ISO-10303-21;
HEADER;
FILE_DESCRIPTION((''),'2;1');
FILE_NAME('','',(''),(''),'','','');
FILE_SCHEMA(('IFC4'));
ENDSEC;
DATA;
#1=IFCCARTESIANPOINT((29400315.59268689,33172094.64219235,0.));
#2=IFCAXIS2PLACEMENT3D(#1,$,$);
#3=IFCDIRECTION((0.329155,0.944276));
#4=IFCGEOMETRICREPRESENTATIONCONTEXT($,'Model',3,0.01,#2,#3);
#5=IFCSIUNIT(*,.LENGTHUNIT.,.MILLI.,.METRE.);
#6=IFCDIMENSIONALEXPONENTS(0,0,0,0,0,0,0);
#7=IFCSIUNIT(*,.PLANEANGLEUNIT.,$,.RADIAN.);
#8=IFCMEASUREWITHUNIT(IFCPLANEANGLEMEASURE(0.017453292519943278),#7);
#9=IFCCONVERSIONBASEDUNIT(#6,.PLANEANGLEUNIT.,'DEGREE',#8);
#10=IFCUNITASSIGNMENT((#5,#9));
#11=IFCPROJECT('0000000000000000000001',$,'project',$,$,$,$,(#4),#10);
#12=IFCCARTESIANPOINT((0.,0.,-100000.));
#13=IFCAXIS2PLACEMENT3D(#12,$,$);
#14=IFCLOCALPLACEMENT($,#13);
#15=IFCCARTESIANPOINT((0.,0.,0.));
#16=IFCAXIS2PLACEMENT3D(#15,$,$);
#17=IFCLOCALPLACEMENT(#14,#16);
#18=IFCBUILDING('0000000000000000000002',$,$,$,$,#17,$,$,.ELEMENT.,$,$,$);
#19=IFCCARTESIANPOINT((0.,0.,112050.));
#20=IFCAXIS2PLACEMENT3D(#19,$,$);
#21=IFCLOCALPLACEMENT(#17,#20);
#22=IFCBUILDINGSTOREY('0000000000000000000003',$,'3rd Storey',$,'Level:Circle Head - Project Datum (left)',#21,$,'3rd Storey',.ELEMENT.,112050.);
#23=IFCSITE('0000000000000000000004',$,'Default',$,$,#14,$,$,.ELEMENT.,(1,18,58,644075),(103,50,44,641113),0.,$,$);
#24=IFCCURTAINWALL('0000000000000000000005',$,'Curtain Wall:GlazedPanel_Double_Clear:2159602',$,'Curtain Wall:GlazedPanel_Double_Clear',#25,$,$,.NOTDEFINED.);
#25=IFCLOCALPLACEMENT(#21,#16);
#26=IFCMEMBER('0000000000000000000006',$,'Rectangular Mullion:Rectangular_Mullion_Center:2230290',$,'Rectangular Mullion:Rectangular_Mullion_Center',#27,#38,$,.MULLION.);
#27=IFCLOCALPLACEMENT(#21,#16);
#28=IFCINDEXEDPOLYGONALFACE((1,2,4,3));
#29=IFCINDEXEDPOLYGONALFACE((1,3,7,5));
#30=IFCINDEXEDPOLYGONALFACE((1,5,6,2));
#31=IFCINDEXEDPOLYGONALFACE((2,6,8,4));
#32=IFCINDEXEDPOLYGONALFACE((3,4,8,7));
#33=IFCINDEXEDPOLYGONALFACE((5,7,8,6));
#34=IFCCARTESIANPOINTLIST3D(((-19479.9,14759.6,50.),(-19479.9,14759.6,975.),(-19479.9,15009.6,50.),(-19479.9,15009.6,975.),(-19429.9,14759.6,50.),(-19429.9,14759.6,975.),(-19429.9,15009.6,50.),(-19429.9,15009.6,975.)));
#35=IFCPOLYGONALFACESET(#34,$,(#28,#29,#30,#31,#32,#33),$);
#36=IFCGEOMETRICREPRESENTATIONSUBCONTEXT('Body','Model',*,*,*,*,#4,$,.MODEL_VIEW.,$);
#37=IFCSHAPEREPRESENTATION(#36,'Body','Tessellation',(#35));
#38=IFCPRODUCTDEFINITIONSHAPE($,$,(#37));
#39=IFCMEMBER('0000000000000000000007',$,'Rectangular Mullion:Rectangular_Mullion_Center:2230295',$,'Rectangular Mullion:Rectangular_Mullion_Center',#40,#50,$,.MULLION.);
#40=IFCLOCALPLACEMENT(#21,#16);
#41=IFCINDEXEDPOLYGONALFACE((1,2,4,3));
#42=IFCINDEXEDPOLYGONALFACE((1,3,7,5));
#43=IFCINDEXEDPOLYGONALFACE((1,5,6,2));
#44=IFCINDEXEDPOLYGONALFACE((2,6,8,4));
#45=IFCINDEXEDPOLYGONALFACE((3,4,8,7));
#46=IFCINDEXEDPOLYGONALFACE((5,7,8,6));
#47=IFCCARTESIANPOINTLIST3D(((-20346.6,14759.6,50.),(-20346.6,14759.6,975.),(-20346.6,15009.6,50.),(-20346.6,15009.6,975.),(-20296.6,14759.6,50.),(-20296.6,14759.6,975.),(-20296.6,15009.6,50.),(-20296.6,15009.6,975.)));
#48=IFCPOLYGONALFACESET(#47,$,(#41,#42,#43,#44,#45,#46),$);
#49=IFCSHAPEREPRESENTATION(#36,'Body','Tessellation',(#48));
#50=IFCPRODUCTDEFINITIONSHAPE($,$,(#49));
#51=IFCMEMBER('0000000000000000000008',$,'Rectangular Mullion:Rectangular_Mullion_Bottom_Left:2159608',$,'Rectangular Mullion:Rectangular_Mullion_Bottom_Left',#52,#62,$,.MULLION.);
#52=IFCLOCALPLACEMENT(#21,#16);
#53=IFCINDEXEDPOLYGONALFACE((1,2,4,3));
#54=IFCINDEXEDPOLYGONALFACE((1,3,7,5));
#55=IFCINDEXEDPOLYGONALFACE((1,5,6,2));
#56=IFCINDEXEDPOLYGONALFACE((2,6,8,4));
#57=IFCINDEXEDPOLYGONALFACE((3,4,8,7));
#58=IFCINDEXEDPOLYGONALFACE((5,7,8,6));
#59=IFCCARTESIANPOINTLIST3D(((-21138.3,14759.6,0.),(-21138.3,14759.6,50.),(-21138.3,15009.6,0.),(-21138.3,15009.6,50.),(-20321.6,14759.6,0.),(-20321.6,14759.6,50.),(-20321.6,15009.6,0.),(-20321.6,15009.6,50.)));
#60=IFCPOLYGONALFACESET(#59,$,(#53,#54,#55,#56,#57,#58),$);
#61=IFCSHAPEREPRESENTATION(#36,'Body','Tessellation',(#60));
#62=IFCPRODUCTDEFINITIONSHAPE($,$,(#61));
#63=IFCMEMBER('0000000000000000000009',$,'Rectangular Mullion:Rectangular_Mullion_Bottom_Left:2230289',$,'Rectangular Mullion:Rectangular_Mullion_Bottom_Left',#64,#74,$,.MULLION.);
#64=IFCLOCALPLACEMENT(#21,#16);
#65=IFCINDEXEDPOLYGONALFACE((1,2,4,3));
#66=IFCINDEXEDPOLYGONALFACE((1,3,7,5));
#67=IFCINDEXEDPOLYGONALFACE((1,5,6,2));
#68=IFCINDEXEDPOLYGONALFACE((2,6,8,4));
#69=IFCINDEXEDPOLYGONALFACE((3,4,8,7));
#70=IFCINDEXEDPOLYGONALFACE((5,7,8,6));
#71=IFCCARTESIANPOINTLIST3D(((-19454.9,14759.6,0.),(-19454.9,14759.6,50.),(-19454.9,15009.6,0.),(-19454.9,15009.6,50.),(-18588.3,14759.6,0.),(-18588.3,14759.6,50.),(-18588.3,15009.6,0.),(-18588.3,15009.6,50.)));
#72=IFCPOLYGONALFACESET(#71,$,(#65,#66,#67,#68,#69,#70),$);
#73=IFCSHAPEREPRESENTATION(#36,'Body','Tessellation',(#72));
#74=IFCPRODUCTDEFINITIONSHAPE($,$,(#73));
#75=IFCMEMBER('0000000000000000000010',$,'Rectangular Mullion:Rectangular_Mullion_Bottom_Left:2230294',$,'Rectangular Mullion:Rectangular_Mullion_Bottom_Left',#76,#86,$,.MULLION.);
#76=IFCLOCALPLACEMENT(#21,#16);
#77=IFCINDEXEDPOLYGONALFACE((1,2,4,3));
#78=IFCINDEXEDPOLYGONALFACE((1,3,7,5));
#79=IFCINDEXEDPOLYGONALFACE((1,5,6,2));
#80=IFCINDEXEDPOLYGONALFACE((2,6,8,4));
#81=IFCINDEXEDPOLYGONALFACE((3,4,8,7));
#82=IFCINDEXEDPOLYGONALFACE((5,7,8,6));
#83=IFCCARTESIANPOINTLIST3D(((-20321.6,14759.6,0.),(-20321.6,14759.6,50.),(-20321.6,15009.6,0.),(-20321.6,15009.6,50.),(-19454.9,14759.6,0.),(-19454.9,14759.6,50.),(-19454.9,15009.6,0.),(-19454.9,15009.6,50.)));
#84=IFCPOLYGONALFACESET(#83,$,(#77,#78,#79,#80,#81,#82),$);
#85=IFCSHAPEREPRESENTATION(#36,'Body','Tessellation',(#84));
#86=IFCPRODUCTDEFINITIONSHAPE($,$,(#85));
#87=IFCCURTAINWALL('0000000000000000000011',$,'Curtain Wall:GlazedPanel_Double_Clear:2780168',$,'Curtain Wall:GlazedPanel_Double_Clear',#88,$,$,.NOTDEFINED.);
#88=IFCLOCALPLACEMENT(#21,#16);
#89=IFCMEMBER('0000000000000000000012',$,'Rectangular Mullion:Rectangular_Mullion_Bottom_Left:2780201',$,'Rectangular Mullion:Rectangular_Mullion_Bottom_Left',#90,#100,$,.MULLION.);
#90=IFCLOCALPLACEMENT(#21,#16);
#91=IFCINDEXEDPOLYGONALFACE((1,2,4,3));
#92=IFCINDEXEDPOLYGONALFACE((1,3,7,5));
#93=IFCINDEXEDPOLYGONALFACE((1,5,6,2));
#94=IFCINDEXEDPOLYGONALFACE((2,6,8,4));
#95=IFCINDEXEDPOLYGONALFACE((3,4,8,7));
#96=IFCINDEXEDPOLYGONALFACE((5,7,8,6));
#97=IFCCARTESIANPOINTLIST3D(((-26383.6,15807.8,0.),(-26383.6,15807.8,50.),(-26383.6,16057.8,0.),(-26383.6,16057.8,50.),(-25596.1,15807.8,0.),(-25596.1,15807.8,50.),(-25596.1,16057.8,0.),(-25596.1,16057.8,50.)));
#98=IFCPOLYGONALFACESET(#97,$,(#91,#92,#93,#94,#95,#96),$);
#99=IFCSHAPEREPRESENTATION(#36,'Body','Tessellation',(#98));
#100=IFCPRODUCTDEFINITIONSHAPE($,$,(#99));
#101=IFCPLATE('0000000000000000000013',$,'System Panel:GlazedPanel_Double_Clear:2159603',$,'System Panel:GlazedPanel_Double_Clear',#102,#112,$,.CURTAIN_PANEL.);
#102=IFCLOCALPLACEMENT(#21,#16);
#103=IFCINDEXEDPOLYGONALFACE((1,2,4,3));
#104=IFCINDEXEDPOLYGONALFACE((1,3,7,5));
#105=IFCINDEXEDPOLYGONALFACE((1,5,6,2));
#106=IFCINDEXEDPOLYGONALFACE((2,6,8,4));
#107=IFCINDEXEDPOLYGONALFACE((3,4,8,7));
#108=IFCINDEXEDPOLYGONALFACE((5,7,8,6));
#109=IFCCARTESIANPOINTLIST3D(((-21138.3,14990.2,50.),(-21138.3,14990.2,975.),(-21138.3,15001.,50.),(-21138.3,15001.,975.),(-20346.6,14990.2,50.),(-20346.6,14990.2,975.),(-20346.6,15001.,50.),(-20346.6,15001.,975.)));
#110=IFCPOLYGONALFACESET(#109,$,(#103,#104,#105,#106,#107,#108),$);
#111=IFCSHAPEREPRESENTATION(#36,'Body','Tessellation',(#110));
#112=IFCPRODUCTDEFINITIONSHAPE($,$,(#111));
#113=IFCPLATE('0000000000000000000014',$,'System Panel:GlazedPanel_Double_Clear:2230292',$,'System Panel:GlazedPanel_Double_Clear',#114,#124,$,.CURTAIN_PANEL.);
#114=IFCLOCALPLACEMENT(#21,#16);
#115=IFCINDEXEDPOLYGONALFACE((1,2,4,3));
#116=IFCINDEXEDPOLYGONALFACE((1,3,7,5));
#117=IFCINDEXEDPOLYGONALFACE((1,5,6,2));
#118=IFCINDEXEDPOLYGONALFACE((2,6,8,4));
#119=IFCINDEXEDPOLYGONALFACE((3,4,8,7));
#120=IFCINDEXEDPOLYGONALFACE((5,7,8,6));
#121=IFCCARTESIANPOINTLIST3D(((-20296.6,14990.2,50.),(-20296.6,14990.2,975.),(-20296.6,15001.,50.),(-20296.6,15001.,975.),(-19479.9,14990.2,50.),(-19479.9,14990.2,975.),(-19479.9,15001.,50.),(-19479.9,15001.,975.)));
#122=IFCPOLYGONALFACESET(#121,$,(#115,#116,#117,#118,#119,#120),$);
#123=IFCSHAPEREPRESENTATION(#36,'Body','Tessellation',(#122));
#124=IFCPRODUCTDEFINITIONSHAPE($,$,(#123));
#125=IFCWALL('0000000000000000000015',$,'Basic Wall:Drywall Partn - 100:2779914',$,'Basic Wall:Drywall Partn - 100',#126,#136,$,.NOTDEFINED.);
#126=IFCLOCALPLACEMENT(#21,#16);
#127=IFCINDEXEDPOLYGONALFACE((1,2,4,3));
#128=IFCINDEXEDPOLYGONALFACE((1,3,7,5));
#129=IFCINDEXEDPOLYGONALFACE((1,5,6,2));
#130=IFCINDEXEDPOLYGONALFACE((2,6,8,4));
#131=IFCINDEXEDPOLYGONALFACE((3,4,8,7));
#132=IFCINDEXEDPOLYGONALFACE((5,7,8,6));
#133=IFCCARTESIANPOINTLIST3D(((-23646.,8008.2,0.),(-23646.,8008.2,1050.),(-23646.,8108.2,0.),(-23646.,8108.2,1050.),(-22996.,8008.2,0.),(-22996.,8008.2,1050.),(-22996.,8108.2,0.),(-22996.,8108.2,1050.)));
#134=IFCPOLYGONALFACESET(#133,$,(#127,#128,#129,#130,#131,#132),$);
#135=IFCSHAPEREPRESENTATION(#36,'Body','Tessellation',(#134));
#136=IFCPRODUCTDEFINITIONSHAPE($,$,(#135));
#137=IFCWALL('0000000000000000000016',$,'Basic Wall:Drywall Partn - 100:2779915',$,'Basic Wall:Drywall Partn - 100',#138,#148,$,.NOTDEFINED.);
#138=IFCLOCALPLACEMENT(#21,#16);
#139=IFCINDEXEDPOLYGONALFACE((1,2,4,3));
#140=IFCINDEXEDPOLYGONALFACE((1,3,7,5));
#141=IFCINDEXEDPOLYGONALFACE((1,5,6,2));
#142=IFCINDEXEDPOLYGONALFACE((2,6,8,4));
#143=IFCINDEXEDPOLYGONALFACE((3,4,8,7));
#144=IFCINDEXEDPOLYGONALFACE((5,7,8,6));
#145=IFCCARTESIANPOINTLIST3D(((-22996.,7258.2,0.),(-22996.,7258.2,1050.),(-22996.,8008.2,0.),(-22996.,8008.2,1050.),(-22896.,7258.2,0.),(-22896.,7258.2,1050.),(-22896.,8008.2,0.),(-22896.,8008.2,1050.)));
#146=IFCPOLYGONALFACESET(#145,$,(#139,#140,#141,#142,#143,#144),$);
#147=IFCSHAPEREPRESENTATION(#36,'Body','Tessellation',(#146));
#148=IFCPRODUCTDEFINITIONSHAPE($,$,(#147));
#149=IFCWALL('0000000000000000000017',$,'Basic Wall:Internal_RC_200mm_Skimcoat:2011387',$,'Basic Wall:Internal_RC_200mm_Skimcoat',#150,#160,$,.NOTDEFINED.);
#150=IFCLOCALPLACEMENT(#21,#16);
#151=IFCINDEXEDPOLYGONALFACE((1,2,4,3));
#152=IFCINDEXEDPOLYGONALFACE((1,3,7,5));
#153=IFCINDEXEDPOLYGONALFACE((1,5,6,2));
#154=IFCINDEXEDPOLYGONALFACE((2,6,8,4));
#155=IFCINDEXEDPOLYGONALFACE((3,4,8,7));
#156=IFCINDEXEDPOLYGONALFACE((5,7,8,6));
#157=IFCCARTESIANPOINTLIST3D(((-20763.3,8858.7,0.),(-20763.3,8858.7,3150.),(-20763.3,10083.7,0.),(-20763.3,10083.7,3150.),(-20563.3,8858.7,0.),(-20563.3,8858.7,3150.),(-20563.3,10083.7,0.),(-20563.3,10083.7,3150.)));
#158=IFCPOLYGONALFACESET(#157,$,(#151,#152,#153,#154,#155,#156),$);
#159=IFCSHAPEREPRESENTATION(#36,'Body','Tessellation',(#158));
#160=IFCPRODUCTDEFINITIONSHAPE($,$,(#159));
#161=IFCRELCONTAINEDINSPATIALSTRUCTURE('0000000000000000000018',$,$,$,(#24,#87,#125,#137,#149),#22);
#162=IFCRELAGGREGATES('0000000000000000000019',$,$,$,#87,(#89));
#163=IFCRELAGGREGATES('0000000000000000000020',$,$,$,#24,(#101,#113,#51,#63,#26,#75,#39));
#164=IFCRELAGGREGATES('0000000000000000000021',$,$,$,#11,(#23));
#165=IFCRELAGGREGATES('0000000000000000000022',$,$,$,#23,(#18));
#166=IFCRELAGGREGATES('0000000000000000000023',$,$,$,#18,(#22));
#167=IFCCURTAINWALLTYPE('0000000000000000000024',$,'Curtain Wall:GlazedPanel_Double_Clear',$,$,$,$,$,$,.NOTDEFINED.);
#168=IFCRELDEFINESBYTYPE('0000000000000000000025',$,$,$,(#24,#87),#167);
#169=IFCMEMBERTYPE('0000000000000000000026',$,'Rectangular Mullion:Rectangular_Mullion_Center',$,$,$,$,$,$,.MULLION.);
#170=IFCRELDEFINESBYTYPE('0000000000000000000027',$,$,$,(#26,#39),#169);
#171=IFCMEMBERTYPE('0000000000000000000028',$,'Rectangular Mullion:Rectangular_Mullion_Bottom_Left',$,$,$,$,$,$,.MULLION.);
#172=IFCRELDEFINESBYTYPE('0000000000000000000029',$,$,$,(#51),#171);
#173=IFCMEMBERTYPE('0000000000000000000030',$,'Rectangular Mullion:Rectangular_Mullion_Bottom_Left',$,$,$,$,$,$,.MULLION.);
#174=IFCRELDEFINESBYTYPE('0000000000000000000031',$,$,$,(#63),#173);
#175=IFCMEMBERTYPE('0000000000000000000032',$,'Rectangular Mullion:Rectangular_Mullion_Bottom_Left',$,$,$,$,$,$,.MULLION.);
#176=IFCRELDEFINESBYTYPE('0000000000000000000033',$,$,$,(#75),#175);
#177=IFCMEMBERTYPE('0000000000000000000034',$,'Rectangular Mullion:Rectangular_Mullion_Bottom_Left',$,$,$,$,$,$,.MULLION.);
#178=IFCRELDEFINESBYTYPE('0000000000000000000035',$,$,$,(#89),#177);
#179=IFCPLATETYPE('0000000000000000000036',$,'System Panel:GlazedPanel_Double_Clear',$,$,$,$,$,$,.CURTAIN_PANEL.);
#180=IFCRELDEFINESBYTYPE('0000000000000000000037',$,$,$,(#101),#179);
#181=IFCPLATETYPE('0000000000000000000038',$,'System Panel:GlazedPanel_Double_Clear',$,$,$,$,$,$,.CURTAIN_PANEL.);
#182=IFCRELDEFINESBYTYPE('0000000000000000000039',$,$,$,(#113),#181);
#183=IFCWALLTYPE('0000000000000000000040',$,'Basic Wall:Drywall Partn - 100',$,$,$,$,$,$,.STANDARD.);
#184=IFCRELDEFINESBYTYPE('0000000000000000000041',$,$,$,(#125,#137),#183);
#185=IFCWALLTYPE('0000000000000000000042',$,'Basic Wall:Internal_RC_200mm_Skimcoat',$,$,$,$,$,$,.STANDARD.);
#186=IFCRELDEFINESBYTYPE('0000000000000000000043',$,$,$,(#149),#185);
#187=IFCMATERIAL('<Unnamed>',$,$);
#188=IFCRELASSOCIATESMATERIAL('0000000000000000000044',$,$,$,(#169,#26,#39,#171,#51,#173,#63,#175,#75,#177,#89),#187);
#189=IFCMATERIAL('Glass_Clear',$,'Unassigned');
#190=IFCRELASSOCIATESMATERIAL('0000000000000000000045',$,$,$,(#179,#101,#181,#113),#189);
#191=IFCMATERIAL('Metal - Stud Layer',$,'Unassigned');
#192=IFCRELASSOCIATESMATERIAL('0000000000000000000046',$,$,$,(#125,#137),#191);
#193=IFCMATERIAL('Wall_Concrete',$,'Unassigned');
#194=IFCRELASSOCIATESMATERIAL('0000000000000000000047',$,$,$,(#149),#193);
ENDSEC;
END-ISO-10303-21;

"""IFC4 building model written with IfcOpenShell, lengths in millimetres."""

from ifc_helpers import new_model, entity, si_unit, converted_unit, direction, frame, origin, place, context, subcontext, project, spatial, indexed_curve, outline, extrude, source, transform, mapped, material, type_object, type_shapes, element, aggregate, save


model = new_model("IFC4")

# Units and contexts
model_context = context("Model", 3, precision=0.01, world=frame((29400315.59268689, 33172094.64219235, 0.0)), true_north=direction((0.329155, 0.944276)))
body_context = subcontext(model_context, "Body", "Model", "MODEL_VIEW")
ifc_project = project(units=[si_unit("LENGTHUNIT", "METRE", prefix="MILLI"), converted_unit("PLANEANGLEUNIT", "DEGREE", entity("IfcPlaneAngleMeasure", 0.017453292519943278), si_unit("PLANEANGLEUNIT", "RADIAN"), dimensions=[0, 0, 0, 0, 0, 0, 0])], contexts=[model_context])

# Site, building, storey
site_placement = place(None, frame((0.0, 0.0, -100000.0)))
site = spatial("IfcSite", under=ifc_project, at=site_placement, Name="Default", CompositionType="ELEMENT", RefLatitude=(1, 18, 58, 644075), RefLongitude=(103, 50, 44, 641113), RefElevation=0.0)
building_placement = place(site_placement, origin())
building = spatial("IfcBuilding", under=site, at=building_placement, CompositionType="ELEMENT")
storey_placement = place(building_placement, frame((0.0, 0.0, 112050.0)))
storey = spatial("IfcBuildingStorey", under=building, at=storey_placement, Name="3rd Storey", ObjectType="Level:Circle Head - Project Datum (left)", LongName="3rd Storey", CompositionType="ELEMENT", Elevation=112050.0)

# Curtain wall, members
curtain_wall_type = type_object("IfcCurtainWallType", Name="Curtain Wall:GlazedPanel_Double_Clear", PredefinedType="NOTDEFINED")
curtain_wall_1_placement = place(storey_placement, frame((0.0, 0.0, -112050.0)))
curtain_wall_1 = element("IfcCurtainWall", 1, at=curtain_wall_1_placement, inside=storey, type_object=curtain_wall_type, Name="Curtain Wall:GlazedPanel_Double_Clear:2159602", ObjectType="Curtain Wall:GlazedPanel_Double_Clear", PredefinedType="NOTDEFINED")
ifc_material_1 = material(Name="<Unnamed>")
member_type_1 = type_object("IfcMemberType", Name="Rectangular Mullion:Rectangular_Mullion_Center", PredefinedType="MULLION", material=ifc_material_1)
shared_shape_1 = source(origin(), body_context, "Body", "SweptSolid", [
    extrude(outline(indexed_curve([(-25.0, -125.0), (25.0, -125.0), (25.0, 125.0), (-25.0, 125.0), (-25.0, -125.0)], self_intersect=False)), frame((0.0, 0.0, -925.0), z_axis=(0.0, 0.0, 1.0), x_axis=(-1.0, 0.0, 0.0)), (0.0, 0.0, 1.0), 925.0),
])
type_shapes(member_type_1, [shared_shape_1])
member_1_placement = place(curtain_wall_1_placement, frame((-19454.9, 14884.6, 112100.0), z_axis=(0.0, 0.0, -1.0), x_axis=(1.0, 0.0, 0.0)))
member_1 = element("IfcMember", 2, at=member_1_placement, type_object=member_type_1, material=ifc_material_1, Name="Rectangular Mullion:Rectangular_Mullion_Center:2230290", ObjectType="Rectangular Mullion:Rectangular_Mullion_Center", PredefinedType="MULLION", context=body_context, shape_type="MappedRepresentation", body=[
    mapped(shared_shape_1, transform((0.0, 0.0, 0.0), scale=1.0)),
])
member_2_placement = place(curtain_wall_1_placement, frame((-20321.6, 14884.6, 112100.0), z_axis=(0.0, 0.0, -1.0), x_axis=(1.0, 0.0, 0.0)))
member_2 = element("IfcMember", 3, at=member_2_placement, type_object=member_type_1, material=ifc_material_1, Name="Rectangular Mullion:Rectangular_Mullion_Center:2230295", ObjectType="Rectangular Mullion:Rectangular_Mullion_Center", PredefinedType="MULLION", context=body_context, shape_type="MappedRepresentation", body=[
    mapped(shared_shape_1, transform((0.0, 0.0, 0.0), scale=1.0)),
])
member_type_2 = type_object("IfcMemberType", Name="Rectangular Mullion:Rectangular_Mullion_Bottom_Left", PredefinedType="MULLION", material=ifc_material_1)
shared_shape_2 = source(origin(), body_context, "Body", "SweptSolid", [
    extrude(outline(indexed_curve([(-25.0, -125.0), (25.0, -125.0), (25.0, 125.0), (-25.0, 125.0), (-25.0, -125.0)], self_intersect=False)), frame((-25.0, 0.0, -816.7), z_axis=(0.0, 0.0, 1.0), x_axis=(-1.0, 0.0, 0.0)), (0.0, 0.0, 1.0), 816.7),
])
type_shapes(member_type_2, [shared_shape_2])
member_3_placement = place(curtain_wall_1_placement, frame((-21138.3, 14884.6, 112050.0), z_axis=(-1.0, 0.0, 0.0), x_axis=(0.0, 0.0, -1.0)))
member_3 = element("IfcMember", 4, at=member_3_placement, type_object=member_type_2, material=ifc_material_1, Name="Rectangular Mullion:Rectangular_Mullion_Bottom_Left:2159608", ObjectType="Rectangular Mullion:Rectangular_Mullion_Bottom_Left", PredefinedType="MULLION", context=body_context, shape_type="MappedRepresentation", body=[
    mapped(shared_shape_2, transform((0.0, 0.0, 0.0), scale=1.0)),
])
member_type_3 = type_object("IfcMemberType", Name="Rectangular Mullion:Rectangular_Mullion_Bottom_Left", PredefinedType="MULLION", material=ifc_material_1)
shared_shape_3 = source(origin(), body_context, "Body", "SweptSolid", [
    extrude(outline(indexed_curve([(-25.0, -125.0), (25.0, -125.0), (25.0, 125.0), (-25.0, 125.0), (-25.0, -125.0)], self_intersect=False)), frame((-25.0, 0.0, -866.7), z_axis=(0.0, 0.0, 1.0), x_axis=(-1.0, 0.0, 0.0)), (0.0, 0.0, 1.0), 866.7),
])
type_shapes(member_type_3, [shared_shape_3])
member_4_placement = place(curtain_wall_1_placement, frame((-19454.9, 14884.6, 112050.0), z_axis=(-1.0, 0.0, 0.0), x_axis=(0.0, 0.0, -1.0)))
member_4 = element("IfcMember", 5, at=member_4_placement, type_object=member_type_3, material=ifc_material_1, Name="Rectangular Mullion:Rectangular_Mullion_Bottom_Left:2230289", ObjectType="Rectangular Mullion:Rectangular_Mullion_Bottom_Left", PredefinedType="MULLION", context=body_context, shape_type="MappedRepresentation", body=[
    mapped(shared_shape_3, transform((0.0, 0.0, 0.0), scale=1.0)),
])
member_type_4 = type_object("IfcMemberType", Name="Rectangular Mullion:Rectangular_Mullion_Bottom_Left", PredefinedType="MULLION", material=ifc_material_1)
shared_shape_4 = source(origin(), body_context, "Body", "SweptSolid", [
    extrude(outline(indexed_curve([(-25.0, -125.0), (25.0, -125.0), (25.0, 125.0), (-25.0, 125.0), (-25.0, -125.0)], self_intersect=False)), frame((-25.0, 0.0, -866.7), z_axis=(0.0, 0.0, 1.0), x_axis=(-1.0, 0.0, 0.0)), (0.0, 0.0, 1.0), 866.7),
])
type_shapes(member_type_4, [shared_shape_4])
member_5_placement = place(curtain_wall_1_placement, frame((-20321.6, 14884.6, 112050.0), z_axis=(-1.0, 0.0, 0.0), x_axis=(0.0, 0.0, -1.0)))
member_5 = element("IfcMember", 6, at=member_5_placement, type_object=member_type_4, material=ifc_material_1, Name="Rectangular Mullion:Rectangular_Mullion_Bottom_Left:2230294", ObjectType="Rectangular Mullion:Rectangular_Mullion_Bottom_Left", PredefinedType="MULLION", context=body_context, shape_type="MappedRepresentation", body=[
    mapped(shared_shape_4, transform((0.0, 0.0, 0.0), scale=1.0)),
])

# Curtain wall, member
curtain_wall_2_placement = place(storey_placement, frame((0.0, 0.0, -112050.0)))
curtain_wall_2 = element("IfcCurtainWall", 7, at=curtain_wall_2_placement, inside=storey, type_object=curtain_wall_type, Name="Curtain Wall:GlazedPanel_Double_Clear:2780168", ObjectType="Curtain Wall:GlazedPanel_Double_Clear", PredefinedType="NOTDEFINED")
member_type_5 = type_object("IfcMemberType", Name="Rectangular Mullion:Rectangular_Mullion_Bottom_Left", PredefinedType="MULLION", material=ifc_material_1)
shared_shape_5 = source(origin(), body_context, "Body", "SweptSolid", [
    extrude(outline(indexed_curve([(-25.0, -125.0), (25.0, -125.0), (25.0, 125.0), (-25.0, 125.0), (-25.0, -125.0)], self_intersect=False)), frame((-25.0, 0.0, -787.5), z_axis=(0.0, 0.0, 1.0), x_axis=(-1.0, 0.0, 0.0)), (0.0, 0.0, 1.0), 787.5),
])
type_shapes(member_type_5, [shared_shape_5])
member_6_placement = place(curtain_wall_2_placement, frame((-26383.6, 15932.8, 112050.0), z_axis=(-1.0, 0.0, 0.0), x_axis=(0.0, 0.0, -1.0)))
member_6 = element("IfcMember", 8, at=member_6_placement, type_object=member_type_5, material=ifc_material_1, Name="Rectangular Mullion:Rectangular_Mullion_Bottom_Left:2780201", ObjectType="Rectangular Mullion:Rectangular_Mullion_Bottom_Left", PredefinedType="MULLION", context=body_context, shape_type="MappedRepresentation", body=[
    mapped(shared_shape_5, transform((0.0, 0.0, 0.0), scale=1.0)),
])
aggregate(curtain_wall_2, [member_6])

# Plates
ifc_material_2 = material(Name="Glass_Clear", Category="Unassigned")
plate_type_1 = type_object("IfcPlateType", Name="System Panel:GlazedPanel_Double_Clear", PredefinedType="CURTAIN_PANEL", material=ifc_material_2)
shared_shape_6 = source(origin(), body_context, "Body", "SweptSolid", [
    extrude(outline(indexed_curve([(-5.4, -395.8), (5.4, -395.8), (5.4, 395.8), (-5.4, 395.8), (-5.4, -395.8)], self_intersect=False)), frame((0.0, 111.0, 0.0), z_axis=(0.0, 0.0, 1.0), x_axis=(0.0, 1.0, 0.0)), (0.0, 0.0, 1.0), 925.0),
])
type_shapes(plate_type_1, [shared_shape_6])
plate_1_placement = place(curtain_wall_1_placement, frame((-20742.5, 14884.6, 112100.0)))
plate_1 = element("IfcPlate", 9, at=plate_1_placement, type_object=plate_type_1, material=ifc_material_2, Name="System Panel:GlazedPanel_Double_Clear:2159603", ObjectType="System Panel:GlazedPanel_Double_Clear", PredefinedType="CURTAIN_PANEL", context=body_context, shape_type="MappedRepresentation", body=[
    mapped(shared_shape_6, transform((0.0, 0.0, 0.0), scale=1.0)),
])
plate_type_2 = type_object("IfcPlateType", Name="System Panel:GlazedPanel_Double_Clear", PredefinedType="CURTAIN_PANEL", material=ifc_material_2)
shared_shape_7 = source(origin(), body_context, "Body", "SweptSolid", [
    extrude(outline(indexed_curve([(-5.4, -408.3), (5.4, -408.3), (5.4, 408.3), (-5.4, 408.3), (-5.4, -408.3)], self_intersect=False)), frame((0.0, 111.0, 0.0), z_axis=(0.0, 0.0, 1.0), x_axis=(0.0, 1.0, 0.0)), (0.0, 0.0, 1.0), 925.0),
])
type_shapes(plate_type_2, [shared_shape_7])
plate_2_placement = place(curtain_wall_1_placement, frame((-19888.3, 14884.6, 112100.0)))
plate_2 = element("IfcPlate", 10, at=plate_2_placement, type_object=plate_type_2, material=ifc_material_2, Name="System Panel:GlazedPanel_Double_Clear:2230292", ObjectType="System Panel:GlazedPanel_Double_Clear", PredefinedType="CURTAIN_PANEL", context=body_context, shape_type="MappedRepresentation", body=[
    mapped(shared_shape_7, transform((0.0, 0.0, 0.0), scale=1.0)),
])
aggregate(curtain_wall_1, [plate_1, plate_2, member_3, member_4, member_1, member_5, member_2])

# Walls
ifc_material_3 = material(Name="Metal - Stud Layer", Category="Unassigned")
wall_type_1 = type_object("IfcWallType", Name="Basic Wall:Drywall Partn - 100", PredefinedType="STANDARD")
wall_1_placement = place(storey_placement, frame((-23646.0, 8058.2, 0.0)))
element("IfcWall", 11, at=wall_1_placement, inside=storey, type_object=wall_type_1, material=ifc_material_3, Name="Basic Wall:Drywall Partn - 100:2779914", ObjectType="Basic Wall:Drywall Partn - 100", PredefinedType="NOTDEFINED", context=body_context, shape_type="SweptSolid", body=[
    extrude(outline(indexed_curve([(650.0, 50.0), (0.0, 50.0), (0.0, -50.0), (650.0, -50.0), (650.0, 50.0)], self_intersect=False)), origin(), (0.0, 0.0, 1.0), 1050.0),
])
wall_2_placement = place(storey_placement, frame((-22946.0, 8008.2, 0.0), z_axis=(0.0, 0.0, 1.0), x_axis=(0.0, -1.0, 0.0)))
element("IfcWall", 12, at=wall_2_placement, inside=storey, type_object=wall_type_1, material=ifc_material_3, Name="Basic Wall:Drywall Partn - 100:2779915", ObjectType="Basic Wall:Drywall Partn - 100", PredefinedType="NOTDEFINED", context=body_context, shape_type="SweptSolid", body=[
    extrude(outline(indexed_curve([(750.0, 50.0), (0.0, 50.0), (0.0, -50.0), (750.0, -50.0), (750.0, 50.0)], self_intersect=False)), origin(), (0.0, 0.0, 1.0), 1050.0),
])
ifc_material_4 = material(Name="Wall_Concrete", Category="Unassigned")
wall_type_2 = type_object("IfcWallType", Name="Basic Wall:Internal_RC_200mm_Skimcoat", PredefinedType="STANDARD")
wall_3_placement = place(storey_placement, frame((-20663.3, 8858.7, 0.0), z_axis=(0.0, 0.0, 1.0), x_axis=(0.0, 1.0, 0.0)))
element("IfcWall", 13, at=wall_3_placement, inside=storey, type_object=wall_type_2, material=ifc_material_4, Name="Basic Wall:Internal_RC_200mm_Skimcoat:2011387", ObjectType="Basic Wall:Internal_RC_200mm_Skimcoat", PredefinedType="NOTDEFINED", context=body_context, shape_type="SweptSolid", body=[
    extrude(outline(indexed_curve([(1225.0, 100.0), (0.0, 100.0), (0.0, -100.0), (1225.0, -100.0), (1225.0, 100.0)], self_intersect=False)), origin(), (0.0, 0.0, 1.0), 3150.0),
])

save(model, "model.ifc")
